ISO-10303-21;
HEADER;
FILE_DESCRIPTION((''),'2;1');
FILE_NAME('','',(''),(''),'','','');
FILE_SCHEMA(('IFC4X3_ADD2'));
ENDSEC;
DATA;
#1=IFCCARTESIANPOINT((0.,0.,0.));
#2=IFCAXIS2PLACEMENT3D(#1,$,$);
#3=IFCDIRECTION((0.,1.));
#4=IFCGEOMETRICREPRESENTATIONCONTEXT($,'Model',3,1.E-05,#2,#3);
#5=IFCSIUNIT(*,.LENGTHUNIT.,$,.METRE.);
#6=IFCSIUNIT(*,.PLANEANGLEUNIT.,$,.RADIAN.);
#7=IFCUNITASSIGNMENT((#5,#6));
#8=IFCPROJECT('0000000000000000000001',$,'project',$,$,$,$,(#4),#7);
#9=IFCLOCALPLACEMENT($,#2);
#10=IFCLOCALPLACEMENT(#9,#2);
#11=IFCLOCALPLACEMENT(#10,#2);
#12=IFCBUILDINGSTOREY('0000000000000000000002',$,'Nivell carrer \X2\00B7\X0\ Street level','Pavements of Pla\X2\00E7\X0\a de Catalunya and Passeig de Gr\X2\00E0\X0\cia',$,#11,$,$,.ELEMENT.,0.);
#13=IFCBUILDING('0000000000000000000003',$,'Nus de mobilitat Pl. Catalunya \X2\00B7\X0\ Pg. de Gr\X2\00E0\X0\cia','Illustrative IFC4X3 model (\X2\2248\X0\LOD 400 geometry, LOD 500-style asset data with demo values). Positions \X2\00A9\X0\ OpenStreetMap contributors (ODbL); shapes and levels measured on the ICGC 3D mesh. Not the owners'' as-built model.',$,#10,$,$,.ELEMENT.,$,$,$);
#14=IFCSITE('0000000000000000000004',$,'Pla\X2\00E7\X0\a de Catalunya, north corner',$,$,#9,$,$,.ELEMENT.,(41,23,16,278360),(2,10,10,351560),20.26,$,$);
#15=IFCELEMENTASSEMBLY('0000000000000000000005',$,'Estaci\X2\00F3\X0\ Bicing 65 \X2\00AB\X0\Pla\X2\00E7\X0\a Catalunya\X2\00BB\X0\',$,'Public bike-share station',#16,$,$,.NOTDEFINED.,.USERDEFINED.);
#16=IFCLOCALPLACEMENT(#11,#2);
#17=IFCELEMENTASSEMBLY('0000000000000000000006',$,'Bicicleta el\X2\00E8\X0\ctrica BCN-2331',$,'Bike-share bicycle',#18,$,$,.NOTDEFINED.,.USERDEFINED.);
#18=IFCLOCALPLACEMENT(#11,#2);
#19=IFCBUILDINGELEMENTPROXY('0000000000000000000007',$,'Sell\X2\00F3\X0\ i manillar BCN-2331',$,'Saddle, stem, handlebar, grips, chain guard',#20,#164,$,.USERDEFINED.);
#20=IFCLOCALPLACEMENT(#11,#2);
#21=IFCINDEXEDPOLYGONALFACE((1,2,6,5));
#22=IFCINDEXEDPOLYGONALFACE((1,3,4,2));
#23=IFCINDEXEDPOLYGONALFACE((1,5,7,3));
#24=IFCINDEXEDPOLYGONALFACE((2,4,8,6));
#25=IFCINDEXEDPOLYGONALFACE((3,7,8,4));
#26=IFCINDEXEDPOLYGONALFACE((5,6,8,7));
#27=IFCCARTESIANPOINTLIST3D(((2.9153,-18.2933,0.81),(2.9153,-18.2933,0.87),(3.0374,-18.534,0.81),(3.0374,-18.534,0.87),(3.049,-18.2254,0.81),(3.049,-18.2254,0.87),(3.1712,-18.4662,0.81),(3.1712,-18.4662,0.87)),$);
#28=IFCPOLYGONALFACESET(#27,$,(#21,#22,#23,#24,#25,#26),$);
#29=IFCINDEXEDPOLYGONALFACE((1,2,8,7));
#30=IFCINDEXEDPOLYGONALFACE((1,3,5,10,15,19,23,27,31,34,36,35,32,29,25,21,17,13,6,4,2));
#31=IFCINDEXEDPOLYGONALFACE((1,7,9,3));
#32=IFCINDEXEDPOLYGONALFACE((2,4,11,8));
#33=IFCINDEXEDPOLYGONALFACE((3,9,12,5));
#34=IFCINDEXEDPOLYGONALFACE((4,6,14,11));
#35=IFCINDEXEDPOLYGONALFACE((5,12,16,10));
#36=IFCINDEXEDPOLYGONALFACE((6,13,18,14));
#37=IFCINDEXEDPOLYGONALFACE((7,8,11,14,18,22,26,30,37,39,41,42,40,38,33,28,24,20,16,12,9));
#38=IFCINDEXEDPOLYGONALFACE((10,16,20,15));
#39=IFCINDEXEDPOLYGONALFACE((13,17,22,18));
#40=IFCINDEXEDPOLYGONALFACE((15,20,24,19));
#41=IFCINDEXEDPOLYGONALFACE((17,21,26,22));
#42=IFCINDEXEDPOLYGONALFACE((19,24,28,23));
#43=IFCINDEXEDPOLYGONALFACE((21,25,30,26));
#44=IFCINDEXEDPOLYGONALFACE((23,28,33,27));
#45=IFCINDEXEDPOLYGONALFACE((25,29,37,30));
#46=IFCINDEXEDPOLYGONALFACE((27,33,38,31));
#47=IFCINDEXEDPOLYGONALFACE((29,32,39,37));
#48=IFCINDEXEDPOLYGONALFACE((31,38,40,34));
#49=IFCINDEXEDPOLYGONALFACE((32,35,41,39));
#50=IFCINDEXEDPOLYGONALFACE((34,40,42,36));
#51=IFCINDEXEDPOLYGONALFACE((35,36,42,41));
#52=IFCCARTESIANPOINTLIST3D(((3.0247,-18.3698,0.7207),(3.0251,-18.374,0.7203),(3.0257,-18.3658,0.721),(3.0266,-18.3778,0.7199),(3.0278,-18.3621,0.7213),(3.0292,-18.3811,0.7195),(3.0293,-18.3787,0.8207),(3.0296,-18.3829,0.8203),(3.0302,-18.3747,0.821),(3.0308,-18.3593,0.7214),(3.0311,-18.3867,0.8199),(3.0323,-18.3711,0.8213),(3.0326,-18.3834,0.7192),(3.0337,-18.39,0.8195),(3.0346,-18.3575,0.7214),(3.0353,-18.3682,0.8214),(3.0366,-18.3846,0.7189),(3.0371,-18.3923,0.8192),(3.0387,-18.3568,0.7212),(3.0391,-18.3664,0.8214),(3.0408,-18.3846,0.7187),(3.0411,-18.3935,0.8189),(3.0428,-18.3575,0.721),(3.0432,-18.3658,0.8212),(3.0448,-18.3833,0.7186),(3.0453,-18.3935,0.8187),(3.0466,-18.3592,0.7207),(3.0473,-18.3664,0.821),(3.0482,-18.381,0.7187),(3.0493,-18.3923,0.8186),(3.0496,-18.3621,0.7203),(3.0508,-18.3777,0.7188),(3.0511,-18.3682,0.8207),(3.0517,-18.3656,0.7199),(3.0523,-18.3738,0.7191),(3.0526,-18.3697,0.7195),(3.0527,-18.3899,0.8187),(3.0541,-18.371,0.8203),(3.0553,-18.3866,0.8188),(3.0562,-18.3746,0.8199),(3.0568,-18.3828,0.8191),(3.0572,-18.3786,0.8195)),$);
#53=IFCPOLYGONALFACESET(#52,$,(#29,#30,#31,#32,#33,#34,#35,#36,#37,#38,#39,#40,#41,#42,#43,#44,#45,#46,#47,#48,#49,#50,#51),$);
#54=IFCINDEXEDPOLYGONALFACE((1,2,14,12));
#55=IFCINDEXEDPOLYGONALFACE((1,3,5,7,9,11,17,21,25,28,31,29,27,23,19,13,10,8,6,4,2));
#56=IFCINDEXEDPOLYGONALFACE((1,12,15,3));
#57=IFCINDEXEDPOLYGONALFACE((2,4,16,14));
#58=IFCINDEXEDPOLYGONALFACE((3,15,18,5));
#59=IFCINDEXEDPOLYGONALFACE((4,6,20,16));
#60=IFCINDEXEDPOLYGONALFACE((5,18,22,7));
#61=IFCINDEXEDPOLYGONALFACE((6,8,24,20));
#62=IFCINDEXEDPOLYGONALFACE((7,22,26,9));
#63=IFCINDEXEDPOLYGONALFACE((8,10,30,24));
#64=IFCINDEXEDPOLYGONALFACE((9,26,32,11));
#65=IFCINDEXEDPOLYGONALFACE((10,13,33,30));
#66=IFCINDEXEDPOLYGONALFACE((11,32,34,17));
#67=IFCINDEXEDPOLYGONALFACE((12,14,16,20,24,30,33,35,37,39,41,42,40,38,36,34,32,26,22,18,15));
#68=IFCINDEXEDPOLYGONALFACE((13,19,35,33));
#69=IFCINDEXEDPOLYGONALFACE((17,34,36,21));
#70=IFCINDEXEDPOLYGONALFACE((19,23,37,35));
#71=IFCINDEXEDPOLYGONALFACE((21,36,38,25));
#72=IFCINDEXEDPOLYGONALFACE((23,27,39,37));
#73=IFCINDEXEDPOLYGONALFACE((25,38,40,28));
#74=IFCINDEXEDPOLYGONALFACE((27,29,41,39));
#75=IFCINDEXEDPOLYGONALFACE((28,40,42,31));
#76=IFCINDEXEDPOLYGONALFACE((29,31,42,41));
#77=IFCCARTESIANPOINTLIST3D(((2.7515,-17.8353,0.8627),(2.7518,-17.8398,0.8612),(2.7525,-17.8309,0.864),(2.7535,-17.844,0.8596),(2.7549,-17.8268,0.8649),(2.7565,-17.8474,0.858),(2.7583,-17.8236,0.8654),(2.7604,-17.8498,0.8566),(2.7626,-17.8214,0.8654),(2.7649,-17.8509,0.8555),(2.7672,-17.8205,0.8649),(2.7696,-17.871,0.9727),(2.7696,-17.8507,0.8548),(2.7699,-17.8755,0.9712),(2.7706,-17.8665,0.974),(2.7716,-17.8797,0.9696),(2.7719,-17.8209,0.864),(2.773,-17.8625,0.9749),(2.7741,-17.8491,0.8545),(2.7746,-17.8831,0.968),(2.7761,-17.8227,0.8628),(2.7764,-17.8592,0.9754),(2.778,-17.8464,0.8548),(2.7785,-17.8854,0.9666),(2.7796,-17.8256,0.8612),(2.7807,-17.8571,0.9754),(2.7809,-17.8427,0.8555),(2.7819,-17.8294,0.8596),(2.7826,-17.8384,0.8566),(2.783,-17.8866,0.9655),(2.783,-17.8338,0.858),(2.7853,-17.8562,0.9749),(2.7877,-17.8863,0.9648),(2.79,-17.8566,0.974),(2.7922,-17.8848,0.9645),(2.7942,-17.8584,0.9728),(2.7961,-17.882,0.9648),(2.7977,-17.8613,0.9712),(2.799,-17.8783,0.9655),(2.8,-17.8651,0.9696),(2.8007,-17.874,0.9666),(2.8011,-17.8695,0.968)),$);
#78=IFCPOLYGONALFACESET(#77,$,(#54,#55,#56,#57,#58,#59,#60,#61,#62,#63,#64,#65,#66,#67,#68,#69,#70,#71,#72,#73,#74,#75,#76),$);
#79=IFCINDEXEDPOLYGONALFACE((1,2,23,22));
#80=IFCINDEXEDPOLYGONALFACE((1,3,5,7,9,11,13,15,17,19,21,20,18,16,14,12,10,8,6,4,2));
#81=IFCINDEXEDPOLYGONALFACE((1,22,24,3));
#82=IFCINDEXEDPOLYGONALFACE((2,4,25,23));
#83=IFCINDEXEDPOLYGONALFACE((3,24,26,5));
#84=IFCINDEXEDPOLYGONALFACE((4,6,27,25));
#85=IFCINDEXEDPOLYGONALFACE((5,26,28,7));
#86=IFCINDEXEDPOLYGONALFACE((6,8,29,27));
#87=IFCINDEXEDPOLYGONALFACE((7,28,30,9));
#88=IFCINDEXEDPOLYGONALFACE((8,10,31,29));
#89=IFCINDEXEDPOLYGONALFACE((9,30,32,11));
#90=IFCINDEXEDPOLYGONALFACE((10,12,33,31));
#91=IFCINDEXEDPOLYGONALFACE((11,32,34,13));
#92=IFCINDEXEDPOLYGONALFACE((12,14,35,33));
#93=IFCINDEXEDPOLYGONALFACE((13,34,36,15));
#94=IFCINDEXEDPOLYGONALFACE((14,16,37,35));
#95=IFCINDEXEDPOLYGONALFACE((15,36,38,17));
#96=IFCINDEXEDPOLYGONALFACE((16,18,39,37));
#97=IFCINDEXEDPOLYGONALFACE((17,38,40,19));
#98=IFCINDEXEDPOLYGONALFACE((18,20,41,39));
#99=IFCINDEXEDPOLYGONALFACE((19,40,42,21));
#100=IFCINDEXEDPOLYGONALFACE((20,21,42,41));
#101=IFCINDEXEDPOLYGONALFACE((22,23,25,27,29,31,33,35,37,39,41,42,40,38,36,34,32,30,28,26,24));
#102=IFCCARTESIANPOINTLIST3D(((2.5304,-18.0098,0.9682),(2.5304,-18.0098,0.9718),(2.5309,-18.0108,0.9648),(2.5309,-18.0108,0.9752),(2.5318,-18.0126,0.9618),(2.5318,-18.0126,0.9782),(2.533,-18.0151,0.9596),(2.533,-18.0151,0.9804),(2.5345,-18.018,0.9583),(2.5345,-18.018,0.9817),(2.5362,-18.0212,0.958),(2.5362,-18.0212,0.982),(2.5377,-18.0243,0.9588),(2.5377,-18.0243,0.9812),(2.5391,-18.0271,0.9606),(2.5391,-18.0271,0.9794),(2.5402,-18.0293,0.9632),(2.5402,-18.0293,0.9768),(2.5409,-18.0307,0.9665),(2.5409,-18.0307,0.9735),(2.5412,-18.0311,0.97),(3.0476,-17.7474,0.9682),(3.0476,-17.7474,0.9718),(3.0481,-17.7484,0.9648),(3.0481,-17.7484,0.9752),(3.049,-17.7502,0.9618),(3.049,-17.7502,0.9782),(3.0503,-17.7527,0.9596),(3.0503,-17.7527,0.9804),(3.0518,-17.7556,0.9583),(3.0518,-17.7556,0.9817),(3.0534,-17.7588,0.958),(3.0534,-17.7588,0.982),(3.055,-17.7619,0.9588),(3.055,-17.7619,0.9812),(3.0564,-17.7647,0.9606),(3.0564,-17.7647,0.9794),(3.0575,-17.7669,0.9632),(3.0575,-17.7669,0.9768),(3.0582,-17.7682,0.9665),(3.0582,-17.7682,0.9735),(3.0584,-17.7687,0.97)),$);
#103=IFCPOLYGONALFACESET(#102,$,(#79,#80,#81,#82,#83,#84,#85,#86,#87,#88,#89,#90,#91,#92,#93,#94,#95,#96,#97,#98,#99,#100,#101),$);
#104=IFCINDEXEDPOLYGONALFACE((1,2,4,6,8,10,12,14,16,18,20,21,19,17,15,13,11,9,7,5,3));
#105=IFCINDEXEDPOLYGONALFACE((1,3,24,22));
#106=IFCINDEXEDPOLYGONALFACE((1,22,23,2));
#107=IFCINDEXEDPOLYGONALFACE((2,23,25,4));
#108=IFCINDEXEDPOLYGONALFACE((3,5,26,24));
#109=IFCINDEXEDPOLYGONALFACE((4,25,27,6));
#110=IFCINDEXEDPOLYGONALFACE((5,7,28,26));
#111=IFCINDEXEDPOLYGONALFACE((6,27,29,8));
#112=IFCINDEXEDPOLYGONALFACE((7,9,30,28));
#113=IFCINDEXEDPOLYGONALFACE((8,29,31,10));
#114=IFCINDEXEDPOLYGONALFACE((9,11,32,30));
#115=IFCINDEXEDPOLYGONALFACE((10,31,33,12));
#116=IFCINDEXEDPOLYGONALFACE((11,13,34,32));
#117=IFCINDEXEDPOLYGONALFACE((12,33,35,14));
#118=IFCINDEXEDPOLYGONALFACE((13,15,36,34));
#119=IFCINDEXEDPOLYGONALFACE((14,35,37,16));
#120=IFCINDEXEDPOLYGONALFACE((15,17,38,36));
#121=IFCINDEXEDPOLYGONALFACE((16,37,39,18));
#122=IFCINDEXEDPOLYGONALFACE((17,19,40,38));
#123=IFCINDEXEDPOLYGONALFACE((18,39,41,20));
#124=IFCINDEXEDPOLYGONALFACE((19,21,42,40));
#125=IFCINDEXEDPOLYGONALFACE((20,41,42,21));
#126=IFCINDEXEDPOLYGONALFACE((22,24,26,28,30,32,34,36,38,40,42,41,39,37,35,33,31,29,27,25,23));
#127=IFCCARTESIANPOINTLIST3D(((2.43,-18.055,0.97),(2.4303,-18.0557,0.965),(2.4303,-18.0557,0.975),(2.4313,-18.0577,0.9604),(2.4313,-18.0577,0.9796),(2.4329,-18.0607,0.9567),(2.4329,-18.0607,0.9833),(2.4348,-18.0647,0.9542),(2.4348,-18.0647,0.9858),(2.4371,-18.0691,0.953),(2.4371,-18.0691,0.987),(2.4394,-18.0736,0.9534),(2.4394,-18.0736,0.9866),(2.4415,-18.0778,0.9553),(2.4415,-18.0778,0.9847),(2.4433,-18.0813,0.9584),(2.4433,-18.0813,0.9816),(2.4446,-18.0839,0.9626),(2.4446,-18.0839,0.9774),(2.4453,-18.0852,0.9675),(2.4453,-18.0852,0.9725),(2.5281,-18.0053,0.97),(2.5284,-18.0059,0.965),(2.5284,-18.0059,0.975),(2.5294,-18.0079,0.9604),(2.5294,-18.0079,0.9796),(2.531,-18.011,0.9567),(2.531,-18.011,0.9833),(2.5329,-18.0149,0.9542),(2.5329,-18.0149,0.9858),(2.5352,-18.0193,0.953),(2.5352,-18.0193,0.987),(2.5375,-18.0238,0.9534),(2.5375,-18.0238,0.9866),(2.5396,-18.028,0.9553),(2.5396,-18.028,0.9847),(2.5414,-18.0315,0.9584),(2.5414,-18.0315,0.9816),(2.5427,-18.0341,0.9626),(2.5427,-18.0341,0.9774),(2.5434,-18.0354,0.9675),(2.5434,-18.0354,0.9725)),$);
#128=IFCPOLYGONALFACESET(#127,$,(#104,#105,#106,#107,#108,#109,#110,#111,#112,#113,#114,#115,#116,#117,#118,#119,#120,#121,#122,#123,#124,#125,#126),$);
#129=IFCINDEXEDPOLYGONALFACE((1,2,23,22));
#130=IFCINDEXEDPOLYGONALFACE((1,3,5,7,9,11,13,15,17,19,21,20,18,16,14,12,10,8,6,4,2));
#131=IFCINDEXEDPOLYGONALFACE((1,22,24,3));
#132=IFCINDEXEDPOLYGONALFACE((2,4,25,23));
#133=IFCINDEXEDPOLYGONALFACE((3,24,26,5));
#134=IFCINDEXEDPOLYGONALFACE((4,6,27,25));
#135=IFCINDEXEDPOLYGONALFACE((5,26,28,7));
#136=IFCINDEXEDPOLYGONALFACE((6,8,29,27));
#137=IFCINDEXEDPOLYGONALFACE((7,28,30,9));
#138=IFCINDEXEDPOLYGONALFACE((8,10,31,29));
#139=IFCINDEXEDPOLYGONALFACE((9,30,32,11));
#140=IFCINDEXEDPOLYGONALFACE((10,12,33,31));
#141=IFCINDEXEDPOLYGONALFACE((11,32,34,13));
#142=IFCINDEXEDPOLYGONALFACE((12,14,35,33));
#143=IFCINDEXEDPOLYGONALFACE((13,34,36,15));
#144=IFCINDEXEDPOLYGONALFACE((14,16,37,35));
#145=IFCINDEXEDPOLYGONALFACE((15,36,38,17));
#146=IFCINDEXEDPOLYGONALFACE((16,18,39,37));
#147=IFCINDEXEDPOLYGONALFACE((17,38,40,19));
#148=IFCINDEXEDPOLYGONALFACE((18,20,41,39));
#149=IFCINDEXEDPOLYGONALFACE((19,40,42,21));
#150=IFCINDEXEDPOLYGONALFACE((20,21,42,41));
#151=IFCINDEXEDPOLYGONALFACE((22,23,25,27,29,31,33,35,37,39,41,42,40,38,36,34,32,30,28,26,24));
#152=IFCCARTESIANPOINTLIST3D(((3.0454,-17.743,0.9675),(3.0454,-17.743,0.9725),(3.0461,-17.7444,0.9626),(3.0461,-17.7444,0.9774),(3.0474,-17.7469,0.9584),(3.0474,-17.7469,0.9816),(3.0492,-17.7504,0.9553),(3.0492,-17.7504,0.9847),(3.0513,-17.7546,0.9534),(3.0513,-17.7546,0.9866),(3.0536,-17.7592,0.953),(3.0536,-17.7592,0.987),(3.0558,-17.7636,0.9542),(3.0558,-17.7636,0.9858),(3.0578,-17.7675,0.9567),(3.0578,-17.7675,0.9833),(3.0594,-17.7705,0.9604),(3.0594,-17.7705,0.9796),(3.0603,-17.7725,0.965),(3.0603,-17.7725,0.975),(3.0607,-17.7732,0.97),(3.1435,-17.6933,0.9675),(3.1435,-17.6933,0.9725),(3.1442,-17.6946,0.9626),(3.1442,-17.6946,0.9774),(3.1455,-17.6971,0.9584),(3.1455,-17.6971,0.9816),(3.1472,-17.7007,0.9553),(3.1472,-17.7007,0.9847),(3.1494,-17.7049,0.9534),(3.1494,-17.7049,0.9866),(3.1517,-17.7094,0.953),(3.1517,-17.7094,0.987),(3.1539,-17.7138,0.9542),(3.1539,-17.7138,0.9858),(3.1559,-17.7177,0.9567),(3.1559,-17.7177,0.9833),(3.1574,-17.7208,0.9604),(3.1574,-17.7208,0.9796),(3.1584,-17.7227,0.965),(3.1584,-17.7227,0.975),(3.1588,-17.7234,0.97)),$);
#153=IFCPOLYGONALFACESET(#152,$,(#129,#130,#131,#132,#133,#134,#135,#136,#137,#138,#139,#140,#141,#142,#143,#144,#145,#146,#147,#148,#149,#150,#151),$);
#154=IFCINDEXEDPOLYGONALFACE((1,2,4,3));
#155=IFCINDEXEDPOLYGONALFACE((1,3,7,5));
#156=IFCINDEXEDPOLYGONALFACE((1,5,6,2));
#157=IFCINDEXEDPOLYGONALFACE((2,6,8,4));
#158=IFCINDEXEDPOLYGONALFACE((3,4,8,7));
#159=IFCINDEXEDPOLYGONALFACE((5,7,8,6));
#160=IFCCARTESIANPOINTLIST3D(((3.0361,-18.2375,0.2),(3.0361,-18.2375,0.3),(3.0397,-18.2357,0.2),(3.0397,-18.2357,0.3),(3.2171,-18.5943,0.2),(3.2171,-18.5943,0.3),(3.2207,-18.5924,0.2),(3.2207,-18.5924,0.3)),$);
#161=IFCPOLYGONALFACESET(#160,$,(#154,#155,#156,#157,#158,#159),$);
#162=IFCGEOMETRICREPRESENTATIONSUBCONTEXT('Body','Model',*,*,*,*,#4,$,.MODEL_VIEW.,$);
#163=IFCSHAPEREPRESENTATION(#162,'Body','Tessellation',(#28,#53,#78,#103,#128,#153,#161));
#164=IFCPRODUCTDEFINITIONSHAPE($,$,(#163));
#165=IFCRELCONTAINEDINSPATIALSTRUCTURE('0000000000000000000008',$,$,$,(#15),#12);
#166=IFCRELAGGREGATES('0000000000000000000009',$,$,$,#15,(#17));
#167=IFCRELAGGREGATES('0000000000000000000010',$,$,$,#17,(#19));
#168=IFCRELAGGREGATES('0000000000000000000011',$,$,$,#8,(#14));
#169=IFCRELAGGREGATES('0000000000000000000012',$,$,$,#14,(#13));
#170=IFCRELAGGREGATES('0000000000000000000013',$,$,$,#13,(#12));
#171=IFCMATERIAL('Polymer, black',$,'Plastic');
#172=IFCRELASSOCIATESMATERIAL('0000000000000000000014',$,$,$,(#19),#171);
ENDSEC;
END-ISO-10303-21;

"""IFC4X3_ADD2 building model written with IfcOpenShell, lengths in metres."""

from ifc_helpers import new_model, si_unit, direction, frame, origin, origin_2d_with_axis, place, context, subcontext, project, spatial, rectangle, circle, extrude, material, element, aggregate, save


model = new_model("IFC4X3_ADD2")

# Units and contexts
model_context = context("Model", 3, precision=1e-05, world=origin(), true_north=direction((0.0, 1.0)))
body_context = subcontext(model_context, "Body", "Model", "MODEL_VIEW")
ifc_project = project(units=[si_unit("LENGTHUNIT", "METRE"), si_unit("PLANEANGLEUNIT", "RADIAN")], contexts=[model_context])

# Site, building, storey
site_placement = place(None, origin())
site = spatial("IfcSite", under=ifc_project, at=site_placement, Name="Plaça de Catalunya, north corner", CompositionType="ELEMENT", RefLatitude=(41, 23, 16, 278360), RefLongitude=(2, 10, 10, 351560), RefElevation=20.26)
building_placement = place(site_placement, origin())
building = spatial("IfcBuilding", under=site, at=building_placement, Name="Nus de mobilitat Pl. Catalunya · Pg. de Gràcia", Description="Illustrative IFC4X3 model (≈LOD 400 geometry, LOD 500-style asset data with demo values). Positions © OpenStreetMap contributors (ODbL); shapes and levels measured on the ICGC 3D mesh. Not the owners' as-built model.", CompositionType="ELEMENT")
storey_placement = place(building_placement, origin())
storey = spatial("IfcBuildingStorey", under=building, at=storey_placement, Name="Nivell carrer · Street level", Description="Pavements of Plaça de Catalunya and Passeig de Gràcia", CompositionType="ELEMENT", Elevation=0.0)

# Element assemblies, building element proxy
assembly_1_placement = place(building_placement, origin())
assembly_1 = element("IfcElementAssembly", 1, at=assembly_1_placement, inside=storey, Name="Estació Bicing 65 «Plaça Catalunya»", ObjectType="Public bike-share station", AssemblyPlace="NOTDEFINED", PredefinedType="USERDEFINED")
ifc_material_1 = material(Name="Polymer, black", Category="Plastic")
assembly_2_placement = place(building_placement, origin())
assembly_2 = element("IfcElementAssembly", 2, at=assembly_2_placement, Name="Bicicleta elèctrica BCN-2331", ObjectType="Bike-share bicycle", AssemblyPlace="NOTDEFINED", PredefinedType="USERDEFINED")
aggregate(assembly_1, [assembly_2])
proxy_1_placement = place(building_placement, origin())
proxy_1 = element("IfcBuildingElementProxy", 3, at=proxy_1_placement, material=ifc_material_1, Name="Selló i manillar BCN-2331", ObjectType="Saddle, stem, handlebar, grips, chain guard", PredefinedType="USERDEFINED", context=body_context, shape_type="SweptSolid", body=[
    extrude(rectangle(XDim=0.27, YDim=0.15, at=origin_2d_with_axis()), frame((3.0432, -18.3797, 0.87), z_axis=(0.0, 0.0, -1.0), x_axis=(-0.452435, 0.891798, 0.0)), (0.0, 0.0, 1.0), 0.06),
    extrude(circle(Radius=0.014, at=origin_2d_with_axis()), frame((3.0387, -18.3708, 0.72), z_axis=(0.045019, -0.088737, 0.995037), x_axis=(0.0, 0.996047, 0.088827)), (0.0, 0.0, 1.0), 0.1005),
    extrude(circle(Radius=0.016, at=origin_2d_with_axis()), frame((2.7672, -17.8357, 0.86), z_axis=(0.154616, -0.304766, 0.939793), x_axis=(0.0, 0.951232, 0.308475)), (0.0, 0.0, 1.0), 0.117),
    extrude(circle(Radius=0.012, at=origin_2d_with_axis()), frame((2.5358, -18.0204, 0.97), z_axis=(0.891798, 0.452435, 0.0), x_axis=(0.452435, -0.891798, 0.0)), (0.0, 0.0, 1.0), 0.58),
    extrude(circle(Radius=0.017, at=origin_2d_with_axis()), frame((2.5358, -18.0204, 0.97), z_axis=(-0.891798, -0.452435, 0.0), x_axis=(-0.452435, 0.891798, 0.0)), (0.0, 0.0, 1.0), 0.11),
    extrude(circle(Radius=0.017, at=origin_2d_with_axis()), frame((3.053, -17.758, 0.97), z_axis=(0.891798, 0.452435, 0.0), x_axis=(0.452435, -0.891798, 0.0)), (0.0, 0.0, 1.0), 0.11),
    extrude(rectangle(XDim=0.4, YDim=0.1, at=origin_2d_with_axis()), frame((3.1266, -18.4159, 0.25), z_axis=(0.891798, 0.452435, 0.0), x_axis=(-0.452435, 0.891798, 0.0)), (0.0, 0.0, 1.0), 0.004),
])
aggregate(assembly_2, [proxy_1])

save(model, "model.ifc")
